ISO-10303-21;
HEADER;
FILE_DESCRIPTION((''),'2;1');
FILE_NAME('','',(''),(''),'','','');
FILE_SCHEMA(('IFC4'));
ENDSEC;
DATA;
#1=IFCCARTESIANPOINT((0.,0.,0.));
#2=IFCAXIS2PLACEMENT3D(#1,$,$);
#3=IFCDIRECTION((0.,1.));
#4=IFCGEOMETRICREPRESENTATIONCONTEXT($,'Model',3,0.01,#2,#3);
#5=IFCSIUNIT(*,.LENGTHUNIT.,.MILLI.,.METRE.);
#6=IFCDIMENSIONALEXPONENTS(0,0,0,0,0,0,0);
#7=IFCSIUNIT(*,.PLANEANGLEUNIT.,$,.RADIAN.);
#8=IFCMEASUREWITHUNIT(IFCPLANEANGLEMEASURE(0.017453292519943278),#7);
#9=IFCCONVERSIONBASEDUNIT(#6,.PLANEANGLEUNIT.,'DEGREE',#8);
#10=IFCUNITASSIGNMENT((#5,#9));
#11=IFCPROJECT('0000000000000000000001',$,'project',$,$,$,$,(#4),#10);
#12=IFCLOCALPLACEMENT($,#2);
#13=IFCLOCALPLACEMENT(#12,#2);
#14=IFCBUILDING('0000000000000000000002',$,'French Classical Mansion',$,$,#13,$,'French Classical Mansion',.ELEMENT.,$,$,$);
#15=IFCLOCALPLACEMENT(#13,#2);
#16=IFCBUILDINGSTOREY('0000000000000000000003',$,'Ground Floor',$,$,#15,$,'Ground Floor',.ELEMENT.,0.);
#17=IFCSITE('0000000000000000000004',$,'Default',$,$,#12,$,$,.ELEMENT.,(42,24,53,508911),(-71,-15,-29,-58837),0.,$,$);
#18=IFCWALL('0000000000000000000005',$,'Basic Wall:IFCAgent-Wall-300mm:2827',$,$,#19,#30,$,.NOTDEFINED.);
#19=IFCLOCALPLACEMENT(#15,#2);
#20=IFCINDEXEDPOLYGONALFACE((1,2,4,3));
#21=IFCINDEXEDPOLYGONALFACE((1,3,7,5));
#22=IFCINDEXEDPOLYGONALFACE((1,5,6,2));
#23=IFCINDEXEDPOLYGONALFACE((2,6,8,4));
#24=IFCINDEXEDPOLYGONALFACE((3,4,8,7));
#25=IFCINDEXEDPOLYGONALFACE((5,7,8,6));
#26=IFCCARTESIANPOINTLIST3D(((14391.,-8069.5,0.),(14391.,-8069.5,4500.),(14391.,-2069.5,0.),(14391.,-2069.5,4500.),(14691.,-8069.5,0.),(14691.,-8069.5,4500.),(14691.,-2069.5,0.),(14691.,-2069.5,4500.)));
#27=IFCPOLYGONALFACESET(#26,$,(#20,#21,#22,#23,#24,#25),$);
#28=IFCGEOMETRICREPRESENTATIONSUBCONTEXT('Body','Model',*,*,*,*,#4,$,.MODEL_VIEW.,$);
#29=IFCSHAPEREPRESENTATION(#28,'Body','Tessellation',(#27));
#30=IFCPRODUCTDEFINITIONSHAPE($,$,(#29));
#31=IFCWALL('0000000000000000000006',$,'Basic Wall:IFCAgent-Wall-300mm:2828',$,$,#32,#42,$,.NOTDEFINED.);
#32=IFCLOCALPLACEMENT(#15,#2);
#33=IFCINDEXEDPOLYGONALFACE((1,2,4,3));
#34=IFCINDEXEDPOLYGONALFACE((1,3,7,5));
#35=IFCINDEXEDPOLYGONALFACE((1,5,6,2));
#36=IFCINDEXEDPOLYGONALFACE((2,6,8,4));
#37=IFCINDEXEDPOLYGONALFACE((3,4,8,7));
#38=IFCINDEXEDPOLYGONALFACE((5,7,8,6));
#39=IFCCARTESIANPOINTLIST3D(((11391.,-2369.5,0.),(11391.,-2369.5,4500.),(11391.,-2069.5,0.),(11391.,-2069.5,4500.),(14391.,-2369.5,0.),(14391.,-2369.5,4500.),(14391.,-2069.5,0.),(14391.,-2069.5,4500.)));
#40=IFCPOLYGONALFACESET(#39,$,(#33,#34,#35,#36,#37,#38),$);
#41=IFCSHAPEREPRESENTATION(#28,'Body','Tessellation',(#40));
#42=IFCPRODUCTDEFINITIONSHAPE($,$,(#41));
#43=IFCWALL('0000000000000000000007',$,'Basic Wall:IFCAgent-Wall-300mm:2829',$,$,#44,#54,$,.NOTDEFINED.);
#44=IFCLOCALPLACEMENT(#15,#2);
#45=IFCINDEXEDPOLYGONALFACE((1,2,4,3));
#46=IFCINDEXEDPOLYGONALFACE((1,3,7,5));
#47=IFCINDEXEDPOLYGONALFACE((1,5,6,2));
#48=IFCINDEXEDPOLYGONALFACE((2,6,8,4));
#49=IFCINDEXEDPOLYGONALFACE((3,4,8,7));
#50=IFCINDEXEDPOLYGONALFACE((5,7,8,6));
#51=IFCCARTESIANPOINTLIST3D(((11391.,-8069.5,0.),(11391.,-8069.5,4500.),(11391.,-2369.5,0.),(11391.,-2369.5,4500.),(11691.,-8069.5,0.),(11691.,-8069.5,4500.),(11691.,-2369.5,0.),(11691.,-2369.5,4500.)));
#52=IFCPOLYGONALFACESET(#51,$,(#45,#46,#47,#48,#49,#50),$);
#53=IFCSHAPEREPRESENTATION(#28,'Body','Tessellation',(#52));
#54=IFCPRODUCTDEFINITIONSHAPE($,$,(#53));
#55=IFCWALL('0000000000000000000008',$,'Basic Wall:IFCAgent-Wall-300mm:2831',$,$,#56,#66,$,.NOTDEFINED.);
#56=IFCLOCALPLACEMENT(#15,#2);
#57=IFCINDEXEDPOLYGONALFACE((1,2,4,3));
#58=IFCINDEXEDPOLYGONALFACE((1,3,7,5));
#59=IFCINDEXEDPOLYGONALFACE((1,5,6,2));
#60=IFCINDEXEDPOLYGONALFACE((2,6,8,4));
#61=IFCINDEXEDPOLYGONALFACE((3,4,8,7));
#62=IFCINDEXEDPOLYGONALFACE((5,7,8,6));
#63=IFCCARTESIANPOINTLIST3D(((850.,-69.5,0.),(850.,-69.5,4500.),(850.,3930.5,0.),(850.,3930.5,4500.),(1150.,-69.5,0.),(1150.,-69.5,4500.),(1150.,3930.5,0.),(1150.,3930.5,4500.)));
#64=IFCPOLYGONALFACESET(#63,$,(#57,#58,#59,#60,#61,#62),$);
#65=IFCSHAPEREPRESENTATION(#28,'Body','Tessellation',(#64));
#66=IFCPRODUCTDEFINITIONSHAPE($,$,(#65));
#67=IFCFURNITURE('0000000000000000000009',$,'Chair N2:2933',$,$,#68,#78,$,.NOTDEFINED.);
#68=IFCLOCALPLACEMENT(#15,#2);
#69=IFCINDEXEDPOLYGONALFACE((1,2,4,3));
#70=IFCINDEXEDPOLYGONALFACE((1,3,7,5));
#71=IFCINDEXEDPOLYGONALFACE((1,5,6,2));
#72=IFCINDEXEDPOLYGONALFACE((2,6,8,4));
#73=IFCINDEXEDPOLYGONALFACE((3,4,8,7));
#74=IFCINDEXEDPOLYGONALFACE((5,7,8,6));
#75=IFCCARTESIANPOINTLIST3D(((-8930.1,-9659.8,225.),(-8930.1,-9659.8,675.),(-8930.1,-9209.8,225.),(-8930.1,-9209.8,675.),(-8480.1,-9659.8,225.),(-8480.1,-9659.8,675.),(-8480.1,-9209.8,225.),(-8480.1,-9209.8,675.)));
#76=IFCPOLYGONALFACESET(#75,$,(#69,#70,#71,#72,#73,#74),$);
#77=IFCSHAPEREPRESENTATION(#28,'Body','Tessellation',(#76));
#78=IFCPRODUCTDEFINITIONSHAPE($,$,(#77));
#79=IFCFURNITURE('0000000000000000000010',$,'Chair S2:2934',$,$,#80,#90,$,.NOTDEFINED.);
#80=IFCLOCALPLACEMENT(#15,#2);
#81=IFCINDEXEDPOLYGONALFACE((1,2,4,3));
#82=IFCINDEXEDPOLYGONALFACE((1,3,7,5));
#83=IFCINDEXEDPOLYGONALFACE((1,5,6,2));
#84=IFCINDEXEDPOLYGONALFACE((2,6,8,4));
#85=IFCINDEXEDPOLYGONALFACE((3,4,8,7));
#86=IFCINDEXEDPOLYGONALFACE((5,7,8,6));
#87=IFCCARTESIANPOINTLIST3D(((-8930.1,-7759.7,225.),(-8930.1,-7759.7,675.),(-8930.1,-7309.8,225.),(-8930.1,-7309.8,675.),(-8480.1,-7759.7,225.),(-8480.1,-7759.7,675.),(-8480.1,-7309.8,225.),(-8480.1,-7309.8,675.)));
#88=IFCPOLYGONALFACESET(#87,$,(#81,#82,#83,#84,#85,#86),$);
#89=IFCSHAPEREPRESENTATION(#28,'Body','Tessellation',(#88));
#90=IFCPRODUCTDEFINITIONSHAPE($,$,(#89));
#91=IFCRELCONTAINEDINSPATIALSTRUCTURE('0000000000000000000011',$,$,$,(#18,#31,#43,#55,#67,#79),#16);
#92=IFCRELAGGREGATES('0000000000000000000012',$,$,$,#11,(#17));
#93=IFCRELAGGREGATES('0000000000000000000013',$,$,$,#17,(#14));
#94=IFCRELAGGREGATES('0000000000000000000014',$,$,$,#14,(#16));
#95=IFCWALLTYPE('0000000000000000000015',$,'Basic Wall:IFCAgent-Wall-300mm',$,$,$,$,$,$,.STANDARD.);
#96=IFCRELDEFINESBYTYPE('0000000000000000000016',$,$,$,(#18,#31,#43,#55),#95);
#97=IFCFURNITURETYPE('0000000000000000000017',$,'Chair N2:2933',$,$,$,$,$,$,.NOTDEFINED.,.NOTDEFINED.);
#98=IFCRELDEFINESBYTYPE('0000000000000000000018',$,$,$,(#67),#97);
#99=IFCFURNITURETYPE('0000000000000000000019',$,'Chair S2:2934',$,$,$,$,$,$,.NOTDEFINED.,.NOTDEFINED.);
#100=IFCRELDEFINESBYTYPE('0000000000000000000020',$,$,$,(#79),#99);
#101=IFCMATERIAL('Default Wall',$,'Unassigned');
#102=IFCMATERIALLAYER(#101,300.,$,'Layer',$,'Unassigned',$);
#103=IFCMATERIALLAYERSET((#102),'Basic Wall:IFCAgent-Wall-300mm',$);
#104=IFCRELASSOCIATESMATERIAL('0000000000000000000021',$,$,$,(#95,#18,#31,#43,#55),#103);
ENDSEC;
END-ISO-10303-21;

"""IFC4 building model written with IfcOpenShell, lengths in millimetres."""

from ifc_helpers import new_model, entity, si_unit, converted_unit, direction, frame, frame_2d, origin, origin_2d_with_axis, place, context, subcontext, project, spatial, rectangle, extrude, material, layer, layer_set, layer_usage, type_object, element, save


model = new_model("IFC4")

# Units and contexts
model_context = context("Model", 3, precision=0.01, world=origin(), true_north=direction((0.0, 1.0)))
body_context = subcontext(model_context, "Body", "Model", "MODEL_VIEW")
ifc_project = project(units=[si_unit("LENGTHUNIT", "METRE", prefix="MILLI"), converted_unit("PLANEANGLEUNIT", "DEGREE", entity("IfcPlaneAngleMeasure", 0.017453292519943278), si_unit("PLANEANGLEUNIT", "RADIAN"), dimensions=[0, 0, 0, 0, 0, 0, 0])], contexts=[model_context])

# Site, building, storey
site_placement = place(None, origin())
site = spatial("IfcSite", under=ifc_project, at=site_placement, Name="Default", CompositionType="ELEMENT", RefLatitude=(42, 24, 53, 508911), RefLongitude=(-71, -15, -29, -58837), RefElevation=0.0)
building_placement = place(site_placement, origin())
building = spatial("IfcBuilding", under=site, at=building_placement, Name="French Classical Mansion", LongName="French Classical Mansion", CompositionType="ELEMENT")
storey_placement = place(building_placement, origin())
storey = spatial("IfcBuildingStorey", under=building, at=storey_placement, Name="Ground Floor", LongName="Ground Floor", CompositionType="ELEMENT", Elevation=0.0)

# Shared definitions
ifc_material = material(Name="Default Wall", Category="Unassigned")
ifc_layer = layer(ifc_material, 300.0, Name="Layer", Category="Unassigned")
ifc_layer_set = layer_set([ifc_layer], Name="Basic Wall:IFCAgent-Wall-300mm")
wall_type = type_object("IfcWallType", Name="Basic Wall:IFCAgent-Wall-300mm", PredefinedType="STANDARD", material=ifc_layer_set)

# Walls
ifc_layer_usage_1 = layer_usage(ifc_layer_set, "AXIS2", "NEGATIVE", 150.0)
wall_1_placement = place(storey_placement, frame((14541.0, -8069.5, 0.0), z_axis=(0.0, 0.0, 1.0), x_axis=(0.0, 1.0, 0.0)))
element("IfcWall", 1, at=wall_1_placement, inside=storey, type_object=wall_type, material=ifc_layer_usage_1, Name="Basic Wall:IFCAgent-Wall-300mm:2827", PredefinedType="NOTDEFINED", context=body_context, shape_type="SweptSolid", body=[
    extrude(rectangle(XDim=6000.0, YDim=300.0, at=frame_2d((3000.0, 0.0), x_axis=(-1.0, 0.0))), origin(), (0.0, 0.0, 1.0), 4500.0),
])
ifc_layer_usage_2 = layer_usage(ifc_layer_set, "AXIS2", "NEGATIVE", 150.0)
wall_2_placement = place(storey_placement, frame((14391.0, -2219.5, 0.0), z_axis=(0.0, 0.0, 1.0), x_axis=(-1.0, 0.0, 0.0)))
element("IfcWall", 2, at=wall_2_placement, inside=storey, type_object=wall_type, material=ifc_layer_usage_2, Name="Basic Wall:IFCAgent-Wall-300mm:2828", PredefinedType="NOTDEFINED", context=body_context, shape_type="SweptSolid", body=[
    extrude(rectangle(XDim=3000.0, YDim=300.0, at=frame_2d((1500.0, 0.0), x_axis=(-1.0, 0.0))), origin(), (0.0, 0.0, 1.0), 4500.0),
])
ifc_layer_usage_3 = layer_usage(ifc_layer_set, "AXIS2", "NEGATIVE", 150.0)
wall_3_placement = place(storey_placement, frame((11541.0, -2369.5, 0.0), z_axis=(0.0, 0.0, 1.0), x_axis=(0.0, -1.0, 0.0)))
element("IfcWall", 3, at=wall_3_placement, inside=storey, type_object=wall_type, material=ifc_layer_usage_3, Name="Basic Wall:IFCAgent-Wall-300mm:2829", PredefinedType="NOTDEFINED", context=body_context, shape_type="SweptSolid", body=[
    extrude(rectangle(XDim=5700.0, YDim=300.0, at=frame_2d((2850.0, 0.0), x_axis=(-1.0, 0.0))), origin(), (0.0, 0.0, 1.0), 4500.0),
])
ifc_layer_usage_4 = layer_usage(ifc_layer_set, "AXIS2", "NEGATIVE", 150.0)
wall_4_placement = place(storey_placement, frame((1000.0, -69.5, 0.0), z_axis=(0.0, 0.0, 1.0), x_axis=(0.0, 1.0, 0.0)))
element("IfcWall", 4, at=wall_4_placement, inside=storey, type_object=wall_type, material=ifc_layer_usage_4, Name="Basic Wall:IFCAgent-Wall-300mm:2831", PredefinedType="NOTDEFINED", context=body_context, shape_type="SweptSolid", body=[
    extrude(rectangle(XDim=4000.0, YDim=300.0, at=frame_2d((2000.0, 0.0), x_axis=(-1.0, 0.0))), origin(), (0.0, 0.0, 1.0), 4500.0),
])

# Furniture
furniture_type_1 = type_object("IfcFurnitureType", Name="Chair N2:2933", PredefinedType="NOTDEFINED")
furniture_1_placement = place(storey_placement, origin())
element("IfcFurniture", 5, at=furniture_1_placement, inside=storey, type_object=furniture_type_1, Name="Chair N2:2933", PredefinedType="NOTDEFINED", context=body_context, shape_type="SweptSolid", body=[
    extrude(rectangle(XDim=450.0, YDim=450.0, at=frame_2d((0.0, 0.0), x_axis=(1.0, 0.0))), frame((-8705.1, -9434.8, 225.0)), (0.0, 0.0, 1.0), 450.0),
])
furniture_type_2 = type_object("IfcFurnitureType", Name="Chair S2:2934", PredefinedType="NOTDEFINED")
furniture_2_placement = place(storey_placement, origin())
element("IfcFurniture", 6, at=furniture_2_placement, inside=storey, type_object=furniture_type_2, Name="Chair S2:2934", PredefinedType="NOTDEFINED", context=body_context, shape_type="SweptSolid", body=[
    extrude(rectangle(XDim=450.0, YDim=450.0, at=origin_2d_with_axis()), frame((-8705.1, -7534.8, 225.0)), (0.0, 0.0, 1.0), 450.0),
])

save(model, "model.ifc")
